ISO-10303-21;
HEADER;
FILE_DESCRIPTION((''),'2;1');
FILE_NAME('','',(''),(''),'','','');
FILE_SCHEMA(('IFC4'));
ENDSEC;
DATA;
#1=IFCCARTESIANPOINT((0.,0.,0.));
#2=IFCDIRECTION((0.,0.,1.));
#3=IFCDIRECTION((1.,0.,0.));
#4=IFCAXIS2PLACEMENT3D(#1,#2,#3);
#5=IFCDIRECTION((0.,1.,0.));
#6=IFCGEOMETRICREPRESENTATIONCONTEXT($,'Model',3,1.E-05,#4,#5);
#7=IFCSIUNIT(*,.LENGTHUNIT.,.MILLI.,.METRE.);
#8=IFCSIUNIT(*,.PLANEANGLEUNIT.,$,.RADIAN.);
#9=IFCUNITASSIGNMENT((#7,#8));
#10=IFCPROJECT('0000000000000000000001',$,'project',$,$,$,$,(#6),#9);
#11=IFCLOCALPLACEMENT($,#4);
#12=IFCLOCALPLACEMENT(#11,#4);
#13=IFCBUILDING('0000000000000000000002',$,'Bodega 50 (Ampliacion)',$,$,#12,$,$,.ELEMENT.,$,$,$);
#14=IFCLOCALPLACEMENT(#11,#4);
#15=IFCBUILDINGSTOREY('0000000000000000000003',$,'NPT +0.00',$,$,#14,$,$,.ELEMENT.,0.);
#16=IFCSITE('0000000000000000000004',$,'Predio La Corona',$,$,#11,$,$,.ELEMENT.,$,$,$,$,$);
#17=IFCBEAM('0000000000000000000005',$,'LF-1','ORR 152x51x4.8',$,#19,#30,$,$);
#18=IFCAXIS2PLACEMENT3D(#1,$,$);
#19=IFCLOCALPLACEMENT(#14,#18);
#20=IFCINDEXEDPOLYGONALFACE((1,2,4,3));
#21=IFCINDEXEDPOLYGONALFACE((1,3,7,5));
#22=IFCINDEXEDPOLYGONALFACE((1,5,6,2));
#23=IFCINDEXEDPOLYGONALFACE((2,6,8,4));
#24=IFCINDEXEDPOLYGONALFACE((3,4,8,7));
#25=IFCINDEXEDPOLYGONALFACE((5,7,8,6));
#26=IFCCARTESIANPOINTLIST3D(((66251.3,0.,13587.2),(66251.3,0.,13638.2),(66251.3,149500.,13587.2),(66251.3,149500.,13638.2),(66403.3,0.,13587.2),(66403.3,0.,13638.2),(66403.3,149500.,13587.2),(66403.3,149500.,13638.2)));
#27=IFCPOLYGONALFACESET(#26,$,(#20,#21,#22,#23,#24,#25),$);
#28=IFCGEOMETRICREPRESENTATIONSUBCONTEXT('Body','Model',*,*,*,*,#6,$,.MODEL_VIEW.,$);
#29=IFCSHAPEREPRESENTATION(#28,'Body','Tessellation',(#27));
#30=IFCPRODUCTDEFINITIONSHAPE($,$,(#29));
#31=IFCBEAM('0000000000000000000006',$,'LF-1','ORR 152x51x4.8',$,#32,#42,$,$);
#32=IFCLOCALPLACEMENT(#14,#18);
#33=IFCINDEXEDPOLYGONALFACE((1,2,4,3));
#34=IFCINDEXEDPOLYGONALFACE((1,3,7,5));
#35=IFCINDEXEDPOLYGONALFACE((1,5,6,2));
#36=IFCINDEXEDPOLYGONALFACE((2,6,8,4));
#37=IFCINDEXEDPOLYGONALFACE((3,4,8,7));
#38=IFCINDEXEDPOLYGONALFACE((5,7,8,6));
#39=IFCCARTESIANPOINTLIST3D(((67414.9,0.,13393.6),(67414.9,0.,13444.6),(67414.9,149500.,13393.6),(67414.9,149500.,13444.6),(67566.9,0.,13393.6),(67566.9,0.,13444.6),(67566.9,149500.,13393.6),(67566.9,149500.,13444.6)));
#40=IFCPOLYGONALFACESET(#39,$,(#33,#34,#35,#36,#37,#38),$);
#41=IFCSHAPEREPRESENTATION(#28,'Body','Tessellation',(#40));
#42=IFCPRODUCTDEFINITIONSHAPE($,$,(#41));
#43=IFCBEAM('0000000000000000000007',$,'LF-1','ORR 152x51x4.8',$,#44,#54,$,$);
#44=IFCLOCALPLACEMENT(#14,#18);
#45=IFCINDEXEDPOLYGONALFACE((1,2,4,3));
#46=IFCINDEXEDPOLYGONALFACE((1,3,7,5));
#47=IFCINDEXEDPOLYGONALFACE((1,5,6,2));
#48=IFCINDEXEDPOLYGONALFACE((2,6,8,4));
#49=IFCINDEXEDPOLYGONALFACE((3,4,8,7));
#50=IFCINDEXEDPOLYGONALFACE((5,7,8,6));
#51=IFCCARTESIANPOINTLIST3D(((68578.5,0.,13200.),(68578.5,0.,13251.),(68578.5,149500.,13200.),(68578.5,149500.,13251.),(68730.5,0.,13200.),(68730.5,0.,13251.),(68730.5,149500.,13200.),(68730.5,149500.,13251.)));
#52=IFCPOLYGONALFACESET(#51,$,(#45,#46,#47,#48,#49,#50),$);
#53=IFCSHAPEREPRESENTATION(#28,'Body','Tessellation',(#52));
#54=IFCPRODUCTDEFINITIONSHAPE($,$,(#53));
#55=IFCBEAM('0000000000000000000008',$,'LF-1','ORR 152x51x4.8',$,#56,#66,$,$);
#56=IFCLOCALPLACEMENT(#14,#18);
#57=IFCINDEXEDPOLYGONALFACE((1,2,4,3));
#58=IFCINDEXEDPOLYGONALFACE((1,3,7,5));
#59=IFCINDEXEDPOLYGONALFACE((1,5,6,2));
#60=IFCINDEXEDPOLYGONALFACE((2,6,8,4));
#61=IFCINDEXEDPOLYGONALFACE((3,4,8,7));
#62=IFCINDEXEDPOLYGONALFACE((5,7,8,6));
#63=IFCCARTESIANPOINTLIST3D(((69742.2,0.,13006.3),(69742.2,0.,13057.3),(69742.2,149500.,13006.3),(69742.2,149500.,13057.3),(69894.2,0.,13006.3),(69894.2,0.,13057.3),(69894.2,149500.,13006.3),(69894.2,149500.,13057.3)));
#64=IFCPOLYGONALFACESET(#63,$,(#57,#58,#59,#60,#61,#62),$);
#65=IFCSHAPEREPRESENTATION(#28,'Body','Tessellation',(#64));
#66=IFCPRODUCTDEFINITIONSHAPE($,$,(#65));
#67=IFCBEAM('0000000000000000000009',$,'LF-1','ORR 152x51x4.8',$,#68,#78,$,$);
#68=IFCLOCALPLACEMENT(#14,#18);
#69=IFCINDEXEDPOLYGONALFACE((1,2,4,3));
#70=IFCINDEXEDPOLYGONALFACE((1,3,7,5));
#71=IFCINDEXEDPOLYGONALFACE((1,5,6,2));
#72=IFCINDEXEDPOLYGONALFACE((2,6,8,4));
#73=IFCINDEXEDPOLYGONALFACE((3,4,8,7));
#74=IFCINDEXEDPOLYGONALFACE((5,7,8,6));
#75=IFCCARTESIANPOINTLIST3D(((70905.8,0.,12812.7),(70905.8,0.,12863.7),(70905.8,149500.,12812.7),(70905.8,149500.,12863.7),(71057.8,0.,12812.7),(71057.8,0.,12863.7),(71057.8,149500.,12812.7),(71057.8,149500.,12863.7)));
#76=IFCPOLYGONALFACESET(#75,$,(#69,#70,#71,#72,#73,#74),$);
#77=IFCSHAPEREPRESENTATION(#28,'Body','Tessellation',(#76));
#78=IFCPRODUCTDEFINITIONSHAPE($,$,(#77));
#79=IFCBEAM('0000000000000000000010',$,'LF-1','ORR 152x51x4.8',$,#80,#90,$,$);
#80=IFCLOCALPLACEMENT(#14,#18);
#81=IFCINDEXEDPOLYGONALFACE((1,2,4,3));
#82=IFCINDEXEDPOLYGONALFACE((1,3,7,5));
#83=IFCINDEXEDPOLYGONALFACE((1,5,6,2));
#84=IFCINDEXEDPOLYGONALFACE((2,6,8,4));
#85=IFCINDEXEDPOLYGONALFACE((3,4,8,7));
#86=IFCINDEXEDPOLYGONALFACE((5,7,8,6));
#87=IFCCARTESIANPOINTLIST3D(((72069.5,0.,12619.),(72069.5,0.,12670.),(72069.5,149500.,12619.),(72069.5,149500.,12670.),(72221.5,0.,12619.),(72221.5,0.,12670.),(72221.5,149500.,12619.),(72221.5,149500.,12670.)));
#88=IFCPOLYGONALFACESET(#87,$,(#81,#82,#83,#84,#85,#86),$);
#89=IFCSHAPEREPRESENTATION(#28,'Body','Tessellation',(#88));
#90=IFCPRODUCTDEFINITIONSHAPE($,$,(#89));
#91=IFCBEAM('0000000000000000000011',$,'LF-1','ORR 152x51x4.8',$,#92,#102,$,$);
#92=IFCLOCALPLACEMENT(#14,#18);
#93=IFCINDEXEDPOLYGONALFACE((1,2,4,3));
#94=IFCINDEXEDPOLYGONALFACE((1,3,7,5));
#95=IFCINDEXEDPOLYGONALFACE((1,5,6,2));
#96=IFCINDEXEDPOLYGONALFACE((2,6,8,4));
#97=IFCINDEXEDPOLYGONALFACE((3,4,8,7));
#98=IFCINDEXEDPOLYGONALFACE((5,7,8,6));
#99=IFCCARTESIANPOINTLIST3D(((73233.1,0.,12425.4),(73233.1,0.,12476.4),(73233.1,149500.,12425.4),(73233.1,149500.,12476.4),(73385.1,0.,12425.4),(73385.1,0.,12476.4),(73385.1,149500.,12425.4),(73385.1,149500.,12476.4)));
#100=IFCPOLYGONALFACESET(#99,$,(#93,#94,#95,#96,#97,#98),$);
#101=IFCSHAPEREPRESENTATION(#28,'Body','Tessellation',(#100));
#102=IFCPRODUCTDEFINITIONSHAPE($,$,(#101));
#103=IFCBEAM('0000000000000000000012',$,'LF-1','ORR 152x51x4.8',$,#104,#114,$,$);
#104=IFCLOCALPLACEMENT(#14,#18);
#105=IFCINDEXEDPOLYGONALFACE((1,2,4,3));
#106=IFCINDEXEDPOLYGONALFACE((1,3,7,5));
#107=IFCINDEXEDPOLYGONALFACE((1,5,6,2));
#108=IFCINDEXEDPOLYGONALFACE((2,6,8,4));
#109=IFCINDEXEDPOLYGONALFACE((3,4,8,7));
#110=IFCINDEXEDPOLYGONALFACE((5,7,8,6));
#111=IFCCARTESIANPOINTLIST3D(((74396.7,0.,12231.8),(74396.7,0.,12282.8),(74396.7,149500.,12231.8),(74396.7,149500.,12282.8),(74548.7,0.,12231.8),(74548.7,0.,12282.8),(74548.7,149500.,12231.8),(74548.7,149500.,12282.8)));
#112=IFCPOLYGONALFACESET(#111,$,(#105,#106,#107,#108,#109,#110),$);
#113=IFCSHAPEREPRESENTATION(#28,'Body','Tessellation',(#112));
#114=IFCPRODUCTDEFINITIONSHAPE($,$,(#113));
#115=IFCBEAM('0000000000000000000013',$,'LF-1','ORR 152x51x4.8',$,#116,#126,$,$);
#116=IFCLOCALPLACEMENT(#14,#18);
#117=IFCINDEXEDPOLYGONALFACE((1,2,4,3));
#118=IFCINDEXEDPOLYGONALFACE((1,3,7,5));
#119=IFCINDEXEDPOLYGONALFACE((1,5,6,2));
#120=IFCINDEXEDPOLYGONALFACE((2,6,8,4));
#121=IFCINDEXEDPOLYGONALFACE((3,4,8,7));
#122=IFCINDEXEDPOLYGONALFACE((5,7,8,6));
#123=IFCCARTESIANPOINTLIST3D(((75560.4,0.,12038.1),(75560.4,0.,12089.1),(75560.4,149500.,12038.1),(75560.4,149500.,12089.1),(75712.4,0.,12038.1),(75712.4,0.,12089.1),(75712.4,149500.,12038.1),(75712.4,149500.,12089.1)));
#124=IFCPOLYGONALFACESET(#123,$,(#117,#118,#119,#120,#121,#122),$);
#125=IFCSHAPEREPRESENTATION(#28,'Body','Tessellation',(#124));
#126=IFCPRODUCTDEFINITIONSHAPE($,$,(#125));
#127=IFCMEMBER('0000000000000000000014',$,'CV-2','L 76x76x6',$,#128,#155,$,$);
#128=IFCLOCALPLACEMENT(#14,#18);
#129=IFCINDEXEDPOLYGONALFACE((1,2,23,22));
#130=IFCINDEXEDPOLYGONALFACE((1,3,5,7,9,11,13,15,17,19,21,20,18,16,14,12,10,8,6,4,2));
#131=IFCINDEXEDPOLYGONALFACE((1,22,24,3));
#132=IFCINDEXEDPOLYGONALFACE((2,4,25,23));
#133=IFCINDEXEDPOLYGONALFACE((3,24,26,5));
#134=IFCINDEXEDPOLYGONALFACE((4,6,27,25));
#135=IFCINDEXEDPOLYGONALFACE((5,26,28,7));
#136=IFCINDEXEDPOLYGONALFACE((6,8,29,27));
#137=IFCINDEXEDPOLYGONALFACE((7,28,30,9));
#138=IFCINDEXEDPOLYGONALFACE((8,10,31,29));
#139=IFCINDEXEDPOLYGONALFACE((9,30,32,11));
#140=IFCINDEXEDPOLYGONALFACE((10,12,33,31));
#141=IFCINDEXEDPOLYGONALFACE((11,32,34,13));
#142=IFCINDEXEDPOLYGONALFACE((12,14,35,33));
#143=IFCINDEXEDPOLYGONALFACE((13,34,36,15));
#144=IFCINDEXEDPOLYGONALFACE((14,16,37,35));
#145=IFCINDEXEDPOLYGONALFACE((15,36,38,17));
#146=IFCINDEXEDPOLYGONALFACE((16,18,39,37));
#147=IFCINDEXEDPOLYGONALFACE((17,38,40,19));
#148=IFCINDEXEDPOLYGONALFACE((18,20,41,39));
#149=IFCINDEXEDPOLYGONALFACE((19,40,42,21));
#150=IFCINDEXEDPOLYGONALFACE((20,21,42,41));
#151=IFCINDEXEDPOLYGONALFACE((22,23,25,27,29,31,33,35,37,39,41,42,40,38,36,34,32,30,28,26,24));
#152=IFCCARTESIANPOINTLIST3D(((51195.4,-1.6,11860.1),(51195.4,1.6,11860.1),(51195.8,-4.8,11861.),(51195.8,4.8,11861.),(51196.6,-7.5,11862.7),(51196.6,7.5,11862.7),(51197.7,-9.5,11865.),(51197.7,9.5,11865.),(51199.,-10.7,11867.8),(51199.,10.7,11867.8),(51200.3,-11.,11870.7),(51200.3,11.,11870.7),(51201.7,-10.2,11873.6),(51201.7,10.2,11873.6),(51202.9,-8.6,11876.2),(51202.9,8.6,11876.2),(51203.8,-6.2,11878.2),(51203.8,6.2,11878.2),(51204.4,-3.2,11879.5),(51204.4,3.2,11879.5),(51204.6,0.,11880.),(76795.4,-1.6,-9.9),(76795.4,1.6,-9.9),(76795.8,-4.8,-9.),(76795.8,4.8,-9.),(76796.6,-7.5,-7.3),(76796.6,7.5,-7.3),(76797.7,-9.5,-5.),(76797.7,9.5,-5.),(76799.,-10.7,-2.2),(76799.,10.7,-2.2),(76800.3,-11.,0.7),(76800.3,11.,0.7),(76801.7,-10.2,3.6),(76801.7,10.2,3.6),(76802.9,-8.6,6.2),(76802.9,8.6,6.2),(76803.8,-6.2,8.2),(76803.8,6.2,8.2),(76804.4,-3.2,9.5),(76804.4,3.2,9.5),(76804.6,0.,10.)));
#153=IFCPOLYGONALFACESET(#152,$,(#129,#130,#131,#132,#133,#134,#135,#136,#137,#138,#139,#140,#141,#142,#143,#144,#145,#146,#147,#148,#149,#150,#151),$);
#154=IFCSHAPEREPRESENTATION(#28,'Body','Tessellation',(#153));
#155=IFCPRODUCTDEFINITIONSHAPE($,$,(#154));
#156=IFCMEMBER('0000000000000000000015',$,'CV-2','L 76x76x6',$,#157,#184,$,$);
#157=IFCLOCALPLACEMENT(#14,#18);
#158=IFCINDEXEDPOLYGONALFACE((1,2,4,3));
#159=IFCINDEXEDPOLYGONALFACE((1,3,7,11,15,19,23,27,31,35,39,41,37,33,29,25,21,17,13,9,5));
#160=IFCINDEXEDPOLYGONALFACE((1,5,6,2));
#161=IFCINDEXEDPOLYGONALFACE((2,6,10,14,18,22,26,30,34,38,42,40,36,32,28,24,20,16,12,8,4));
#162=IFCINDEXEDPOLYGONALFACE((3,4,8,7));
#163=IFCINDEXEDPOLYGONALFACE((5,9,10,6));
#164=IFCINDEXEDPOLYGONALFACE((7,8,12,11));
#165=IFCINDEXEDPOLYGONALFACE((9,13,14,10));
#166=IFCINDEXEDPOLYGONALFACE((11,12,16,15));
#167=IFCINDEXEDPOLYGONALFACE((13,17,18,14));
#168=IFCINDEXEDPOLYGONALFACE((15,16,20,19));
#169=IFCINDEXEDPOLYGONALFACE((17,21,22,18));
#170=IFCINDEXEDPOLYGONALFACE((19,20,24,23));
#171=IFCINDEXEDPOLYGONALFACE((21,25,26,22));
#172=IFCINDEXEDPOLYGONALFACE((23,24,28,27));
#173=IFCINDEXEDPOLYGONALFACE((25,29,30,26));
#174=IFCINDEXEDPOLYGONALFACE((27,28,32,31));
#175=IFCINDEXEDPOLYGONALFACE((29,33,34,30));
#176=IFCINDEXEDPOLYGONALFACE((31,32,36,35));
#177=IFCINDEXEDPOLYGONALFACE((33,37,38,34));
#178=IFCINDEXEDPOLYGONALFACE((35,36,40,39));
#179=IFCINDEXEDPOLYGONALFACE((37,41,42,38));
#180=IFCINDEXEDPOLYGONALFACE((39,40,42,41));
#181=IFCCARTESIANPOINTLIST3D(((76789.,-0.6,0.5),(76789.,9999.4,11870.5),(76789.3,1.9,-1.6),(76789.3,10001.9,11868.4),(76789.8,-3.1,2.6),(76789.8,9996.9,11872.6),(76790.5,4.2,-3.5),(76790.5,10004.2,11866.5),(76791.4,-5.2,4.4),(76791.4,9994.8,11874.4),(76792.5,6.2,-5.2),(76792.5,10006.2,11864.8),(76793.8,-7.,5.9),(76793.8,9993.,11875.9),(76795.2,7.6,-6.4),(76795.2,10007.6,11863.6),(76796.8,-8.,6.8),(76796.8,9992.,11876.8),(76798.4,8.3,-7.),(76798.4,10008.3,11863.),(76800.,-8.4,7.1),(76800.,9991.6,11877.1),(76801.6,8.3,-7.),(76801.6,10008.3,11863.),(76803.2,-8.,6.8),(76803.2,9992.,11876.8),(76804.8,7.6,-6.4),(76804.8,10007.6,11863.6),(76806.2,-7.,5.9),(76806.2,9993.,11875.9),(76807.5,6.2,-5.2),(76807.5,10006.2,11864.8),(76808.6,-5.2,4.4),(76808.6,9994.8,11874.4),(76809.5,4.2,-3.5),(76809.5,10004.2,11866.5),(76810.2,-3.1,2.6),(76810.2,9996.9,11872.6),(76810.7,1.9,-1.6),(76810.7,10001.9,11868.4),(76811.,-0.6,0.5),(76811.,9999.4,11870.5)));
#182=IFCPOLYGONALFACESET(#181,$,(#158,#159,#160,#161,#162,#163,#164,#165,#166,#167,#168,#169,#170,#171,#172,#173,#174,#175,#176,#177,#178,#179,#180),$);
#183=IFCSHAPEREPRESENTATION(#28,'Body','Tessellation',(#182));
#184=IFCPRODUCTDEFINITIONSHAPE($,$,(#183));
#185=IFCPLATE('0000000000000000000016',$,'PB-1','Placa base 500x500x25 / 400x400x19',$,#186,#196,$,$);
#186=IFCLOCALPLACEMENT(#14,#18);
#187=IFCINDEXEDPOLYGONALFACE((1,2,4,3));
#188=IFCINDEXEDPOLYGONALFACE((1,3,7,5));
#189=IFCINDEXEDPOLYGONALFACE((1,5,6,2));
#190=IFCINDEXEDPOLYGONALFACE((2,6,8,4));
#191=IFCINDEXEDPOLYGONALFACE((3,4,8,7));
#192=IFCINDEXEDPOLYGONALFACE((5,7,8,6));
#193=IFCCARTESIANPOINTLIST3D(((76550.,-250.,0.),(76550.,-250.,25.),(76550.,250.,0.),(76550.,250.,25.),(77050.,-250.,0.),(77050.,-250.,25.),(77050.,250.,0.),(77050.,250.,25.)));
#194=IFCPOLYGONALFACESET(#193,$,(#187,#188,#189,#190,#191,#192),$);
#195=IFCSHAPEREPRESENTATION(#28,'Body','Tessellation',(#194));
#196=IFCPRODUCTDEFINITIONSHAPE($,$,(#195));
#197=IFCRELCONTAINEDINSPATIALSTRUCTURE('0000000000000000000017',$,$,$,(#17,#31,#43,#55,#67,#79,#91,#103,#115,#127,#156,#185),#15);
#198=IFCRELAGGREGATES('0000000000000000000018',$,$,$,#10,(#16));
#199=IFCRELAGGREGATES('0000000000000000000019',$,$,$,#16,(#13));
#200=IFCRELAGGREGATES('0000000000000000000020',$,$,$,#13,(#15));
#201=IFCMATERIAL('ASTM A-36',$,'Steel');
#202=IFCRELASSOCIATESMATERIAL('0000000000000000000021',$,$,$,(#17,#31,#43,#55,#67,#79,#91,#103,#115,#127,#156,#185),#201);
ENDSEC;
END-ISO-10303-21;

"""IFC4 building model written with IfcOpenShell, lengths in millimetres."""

from ifc_helpers import new_model, si_unit, direction, frame, origin_with_axes, origin_2d, place, context, subcontext, project, spatial, rectangle, circle, extrude, material, element, save


model = new_model("IFC4")

# Units and contexts
model_context = context("Model", 3, precision=1e-05, world=origin_with_axes(), true_north=direction((0.0, 1.0, 0.0)))
body_context = subcontext(model_context, "Body", "Model", "MODEL_VIEW")
ifc_project = project(units=[si_unit("LENGTHUNIT", "METRE", prefix="MILLI"), si_unit("PLANEANGLEUNIT", "RADIAN")], contexts=[model_context])

# Site, building, storey
site_placement = place(None, origin_with_axes())
site = spatial("IfcSite", under=ifc_project, at=site_placement, Name="Predio La Corona", CompositionType="ELEMENT")
building_placement = place(site_placement, origin_with_axes())
building = spatial("IfcBuilding", under=site, at=building_placement, Name="Bodega 50 (Ampliacion)", CompositionType="ELEMENT")
storey_placement = place(site_placement, origin_with_axes())
storey = spatial("IfcBuildingStorey", under=building, at=storey_placement, Name="NPT +0.00", CompositionType="ELEMENT", Elevation=0.0)

# Shared definitions
ifc_material = material(Name="ASTM A-36", Category="Steel")

# Beams
for number, where, z_axis, x_axis, name in (
    (1, (66327.3, 0.0, 13612.7), (0.0, 1.0, 0.0), (0.0, 0.0, 1.0), "LF-1"),
    (2, (67490.9, 0.0, 13419.1), (0.0, 1.0, 0.0), (0.0, 0.0, 1.0), "LF-1"),
    (3, (68654.5, 0.0, 13225.5), (0.0, 1.0, 0.0), (0.0, 0.0, 1.0), "LF-1"),
    (4, (69818.2, 0.0, 13031.8), (0.0, 1.0, 0.0), (0.0, 0.0, 1.0), "LF-1"),
    (5, (70981.8, 0.0, 12838.2), (0.0, 1.0, 0.0), (0.0, 0.0, 1.0), "LF-1"),
    (6, (72145.5, 0.0, 12644.5), (0.0, 1.0, 0.0), (0.0, 0.0, 1.0), "LF-1"),
    (7, (73309.1, 0.0, 12450.9), (0.0, 1.0, 0.0), (0.0, 0.0, 1.0), "LF-1"),
    (8, (74472.7, 0.0, 12257.3), (0.0, 1.0, 0.0), (0.0, 0.0, 1.0), "LF-1"),
    (9, (75636.4, 0.0, 12063.6), (0.0, 1.0, 0.0), (0.0, 0.0, 1.0), "LF-1"),
):
    element("IfcBeam", number, at=place(storey_placement, frame(where, z_axis=z_axis, x_axis=x_axis)), inside=storey, material=ifc_material, Name=name, Description="ORR 152x51x4.8", context=body_context, shape_type="SweptSolid", body=[
        extrude(rectangle(XDim=51.0, YDim=152.0, at=origin_2d()), origin_with_axes(), (0.0, 0.0, 1.0), 149500.0),
    ])

# Members
member_1_placement = place(storey_placement, frame((76800.0, 0.0, 0.0), z_axis=(-0.907222, 0.0, 0.420653), x_axis=(0.420653, 0.0, 0.907222)))
element("IfcMember", 10, at=member_1_placement, inside=storey, material=ifc_material, Name="CV-2", Description="L 76x76x6", context=body_context, shape_type="SweptSolid", body=[
    extrude(circle(Radius=11.0, at=origin_2d()), origin_with_axes(), (0.0, 0.0, 1.0), 28218.0),
])
member_2_placement = place(storey_placement, frame((76800.0, 0.0, 0.0), z_axis=(0.0, 0.644294, 0.764778), x_axis=(0.0, -0.764778, 0.644294)))
element("IfcMember", 11, at=member_2_placement, inside=storey, material=ifc_material, Name="CV-2", Description="L 76x76x6", context=body_context, shape_type="SweptSolid", body=[
    extrude(circle(Radius=11.0, at=origin_2d()), origin_with_axes(), (0.0, 0.0, 1.0), 15520.9),
])

# Plate
plate_placement = place(storey_placement, frame((76800.0, 0.0, 0.0), z_axis=(0.0, 0.0, 1.0), x_axis=(1.0, 0.0, 0.0)))
element("IfcPlate", 12, at=plate_placement, inside=storey, material=ifc_material, Name="PB-1", Description="Placa base 500x500x25 / 400x400x19", context=body_context, shape_type="SweptSolid", body=[
    extrude(rectangle(XDim=500.0, YDim=500.0, at=origin_2d()), origin_with_axes(), (0.0, 0.0, 1.0), 25.0),
])

save(model, "model.ifc")
